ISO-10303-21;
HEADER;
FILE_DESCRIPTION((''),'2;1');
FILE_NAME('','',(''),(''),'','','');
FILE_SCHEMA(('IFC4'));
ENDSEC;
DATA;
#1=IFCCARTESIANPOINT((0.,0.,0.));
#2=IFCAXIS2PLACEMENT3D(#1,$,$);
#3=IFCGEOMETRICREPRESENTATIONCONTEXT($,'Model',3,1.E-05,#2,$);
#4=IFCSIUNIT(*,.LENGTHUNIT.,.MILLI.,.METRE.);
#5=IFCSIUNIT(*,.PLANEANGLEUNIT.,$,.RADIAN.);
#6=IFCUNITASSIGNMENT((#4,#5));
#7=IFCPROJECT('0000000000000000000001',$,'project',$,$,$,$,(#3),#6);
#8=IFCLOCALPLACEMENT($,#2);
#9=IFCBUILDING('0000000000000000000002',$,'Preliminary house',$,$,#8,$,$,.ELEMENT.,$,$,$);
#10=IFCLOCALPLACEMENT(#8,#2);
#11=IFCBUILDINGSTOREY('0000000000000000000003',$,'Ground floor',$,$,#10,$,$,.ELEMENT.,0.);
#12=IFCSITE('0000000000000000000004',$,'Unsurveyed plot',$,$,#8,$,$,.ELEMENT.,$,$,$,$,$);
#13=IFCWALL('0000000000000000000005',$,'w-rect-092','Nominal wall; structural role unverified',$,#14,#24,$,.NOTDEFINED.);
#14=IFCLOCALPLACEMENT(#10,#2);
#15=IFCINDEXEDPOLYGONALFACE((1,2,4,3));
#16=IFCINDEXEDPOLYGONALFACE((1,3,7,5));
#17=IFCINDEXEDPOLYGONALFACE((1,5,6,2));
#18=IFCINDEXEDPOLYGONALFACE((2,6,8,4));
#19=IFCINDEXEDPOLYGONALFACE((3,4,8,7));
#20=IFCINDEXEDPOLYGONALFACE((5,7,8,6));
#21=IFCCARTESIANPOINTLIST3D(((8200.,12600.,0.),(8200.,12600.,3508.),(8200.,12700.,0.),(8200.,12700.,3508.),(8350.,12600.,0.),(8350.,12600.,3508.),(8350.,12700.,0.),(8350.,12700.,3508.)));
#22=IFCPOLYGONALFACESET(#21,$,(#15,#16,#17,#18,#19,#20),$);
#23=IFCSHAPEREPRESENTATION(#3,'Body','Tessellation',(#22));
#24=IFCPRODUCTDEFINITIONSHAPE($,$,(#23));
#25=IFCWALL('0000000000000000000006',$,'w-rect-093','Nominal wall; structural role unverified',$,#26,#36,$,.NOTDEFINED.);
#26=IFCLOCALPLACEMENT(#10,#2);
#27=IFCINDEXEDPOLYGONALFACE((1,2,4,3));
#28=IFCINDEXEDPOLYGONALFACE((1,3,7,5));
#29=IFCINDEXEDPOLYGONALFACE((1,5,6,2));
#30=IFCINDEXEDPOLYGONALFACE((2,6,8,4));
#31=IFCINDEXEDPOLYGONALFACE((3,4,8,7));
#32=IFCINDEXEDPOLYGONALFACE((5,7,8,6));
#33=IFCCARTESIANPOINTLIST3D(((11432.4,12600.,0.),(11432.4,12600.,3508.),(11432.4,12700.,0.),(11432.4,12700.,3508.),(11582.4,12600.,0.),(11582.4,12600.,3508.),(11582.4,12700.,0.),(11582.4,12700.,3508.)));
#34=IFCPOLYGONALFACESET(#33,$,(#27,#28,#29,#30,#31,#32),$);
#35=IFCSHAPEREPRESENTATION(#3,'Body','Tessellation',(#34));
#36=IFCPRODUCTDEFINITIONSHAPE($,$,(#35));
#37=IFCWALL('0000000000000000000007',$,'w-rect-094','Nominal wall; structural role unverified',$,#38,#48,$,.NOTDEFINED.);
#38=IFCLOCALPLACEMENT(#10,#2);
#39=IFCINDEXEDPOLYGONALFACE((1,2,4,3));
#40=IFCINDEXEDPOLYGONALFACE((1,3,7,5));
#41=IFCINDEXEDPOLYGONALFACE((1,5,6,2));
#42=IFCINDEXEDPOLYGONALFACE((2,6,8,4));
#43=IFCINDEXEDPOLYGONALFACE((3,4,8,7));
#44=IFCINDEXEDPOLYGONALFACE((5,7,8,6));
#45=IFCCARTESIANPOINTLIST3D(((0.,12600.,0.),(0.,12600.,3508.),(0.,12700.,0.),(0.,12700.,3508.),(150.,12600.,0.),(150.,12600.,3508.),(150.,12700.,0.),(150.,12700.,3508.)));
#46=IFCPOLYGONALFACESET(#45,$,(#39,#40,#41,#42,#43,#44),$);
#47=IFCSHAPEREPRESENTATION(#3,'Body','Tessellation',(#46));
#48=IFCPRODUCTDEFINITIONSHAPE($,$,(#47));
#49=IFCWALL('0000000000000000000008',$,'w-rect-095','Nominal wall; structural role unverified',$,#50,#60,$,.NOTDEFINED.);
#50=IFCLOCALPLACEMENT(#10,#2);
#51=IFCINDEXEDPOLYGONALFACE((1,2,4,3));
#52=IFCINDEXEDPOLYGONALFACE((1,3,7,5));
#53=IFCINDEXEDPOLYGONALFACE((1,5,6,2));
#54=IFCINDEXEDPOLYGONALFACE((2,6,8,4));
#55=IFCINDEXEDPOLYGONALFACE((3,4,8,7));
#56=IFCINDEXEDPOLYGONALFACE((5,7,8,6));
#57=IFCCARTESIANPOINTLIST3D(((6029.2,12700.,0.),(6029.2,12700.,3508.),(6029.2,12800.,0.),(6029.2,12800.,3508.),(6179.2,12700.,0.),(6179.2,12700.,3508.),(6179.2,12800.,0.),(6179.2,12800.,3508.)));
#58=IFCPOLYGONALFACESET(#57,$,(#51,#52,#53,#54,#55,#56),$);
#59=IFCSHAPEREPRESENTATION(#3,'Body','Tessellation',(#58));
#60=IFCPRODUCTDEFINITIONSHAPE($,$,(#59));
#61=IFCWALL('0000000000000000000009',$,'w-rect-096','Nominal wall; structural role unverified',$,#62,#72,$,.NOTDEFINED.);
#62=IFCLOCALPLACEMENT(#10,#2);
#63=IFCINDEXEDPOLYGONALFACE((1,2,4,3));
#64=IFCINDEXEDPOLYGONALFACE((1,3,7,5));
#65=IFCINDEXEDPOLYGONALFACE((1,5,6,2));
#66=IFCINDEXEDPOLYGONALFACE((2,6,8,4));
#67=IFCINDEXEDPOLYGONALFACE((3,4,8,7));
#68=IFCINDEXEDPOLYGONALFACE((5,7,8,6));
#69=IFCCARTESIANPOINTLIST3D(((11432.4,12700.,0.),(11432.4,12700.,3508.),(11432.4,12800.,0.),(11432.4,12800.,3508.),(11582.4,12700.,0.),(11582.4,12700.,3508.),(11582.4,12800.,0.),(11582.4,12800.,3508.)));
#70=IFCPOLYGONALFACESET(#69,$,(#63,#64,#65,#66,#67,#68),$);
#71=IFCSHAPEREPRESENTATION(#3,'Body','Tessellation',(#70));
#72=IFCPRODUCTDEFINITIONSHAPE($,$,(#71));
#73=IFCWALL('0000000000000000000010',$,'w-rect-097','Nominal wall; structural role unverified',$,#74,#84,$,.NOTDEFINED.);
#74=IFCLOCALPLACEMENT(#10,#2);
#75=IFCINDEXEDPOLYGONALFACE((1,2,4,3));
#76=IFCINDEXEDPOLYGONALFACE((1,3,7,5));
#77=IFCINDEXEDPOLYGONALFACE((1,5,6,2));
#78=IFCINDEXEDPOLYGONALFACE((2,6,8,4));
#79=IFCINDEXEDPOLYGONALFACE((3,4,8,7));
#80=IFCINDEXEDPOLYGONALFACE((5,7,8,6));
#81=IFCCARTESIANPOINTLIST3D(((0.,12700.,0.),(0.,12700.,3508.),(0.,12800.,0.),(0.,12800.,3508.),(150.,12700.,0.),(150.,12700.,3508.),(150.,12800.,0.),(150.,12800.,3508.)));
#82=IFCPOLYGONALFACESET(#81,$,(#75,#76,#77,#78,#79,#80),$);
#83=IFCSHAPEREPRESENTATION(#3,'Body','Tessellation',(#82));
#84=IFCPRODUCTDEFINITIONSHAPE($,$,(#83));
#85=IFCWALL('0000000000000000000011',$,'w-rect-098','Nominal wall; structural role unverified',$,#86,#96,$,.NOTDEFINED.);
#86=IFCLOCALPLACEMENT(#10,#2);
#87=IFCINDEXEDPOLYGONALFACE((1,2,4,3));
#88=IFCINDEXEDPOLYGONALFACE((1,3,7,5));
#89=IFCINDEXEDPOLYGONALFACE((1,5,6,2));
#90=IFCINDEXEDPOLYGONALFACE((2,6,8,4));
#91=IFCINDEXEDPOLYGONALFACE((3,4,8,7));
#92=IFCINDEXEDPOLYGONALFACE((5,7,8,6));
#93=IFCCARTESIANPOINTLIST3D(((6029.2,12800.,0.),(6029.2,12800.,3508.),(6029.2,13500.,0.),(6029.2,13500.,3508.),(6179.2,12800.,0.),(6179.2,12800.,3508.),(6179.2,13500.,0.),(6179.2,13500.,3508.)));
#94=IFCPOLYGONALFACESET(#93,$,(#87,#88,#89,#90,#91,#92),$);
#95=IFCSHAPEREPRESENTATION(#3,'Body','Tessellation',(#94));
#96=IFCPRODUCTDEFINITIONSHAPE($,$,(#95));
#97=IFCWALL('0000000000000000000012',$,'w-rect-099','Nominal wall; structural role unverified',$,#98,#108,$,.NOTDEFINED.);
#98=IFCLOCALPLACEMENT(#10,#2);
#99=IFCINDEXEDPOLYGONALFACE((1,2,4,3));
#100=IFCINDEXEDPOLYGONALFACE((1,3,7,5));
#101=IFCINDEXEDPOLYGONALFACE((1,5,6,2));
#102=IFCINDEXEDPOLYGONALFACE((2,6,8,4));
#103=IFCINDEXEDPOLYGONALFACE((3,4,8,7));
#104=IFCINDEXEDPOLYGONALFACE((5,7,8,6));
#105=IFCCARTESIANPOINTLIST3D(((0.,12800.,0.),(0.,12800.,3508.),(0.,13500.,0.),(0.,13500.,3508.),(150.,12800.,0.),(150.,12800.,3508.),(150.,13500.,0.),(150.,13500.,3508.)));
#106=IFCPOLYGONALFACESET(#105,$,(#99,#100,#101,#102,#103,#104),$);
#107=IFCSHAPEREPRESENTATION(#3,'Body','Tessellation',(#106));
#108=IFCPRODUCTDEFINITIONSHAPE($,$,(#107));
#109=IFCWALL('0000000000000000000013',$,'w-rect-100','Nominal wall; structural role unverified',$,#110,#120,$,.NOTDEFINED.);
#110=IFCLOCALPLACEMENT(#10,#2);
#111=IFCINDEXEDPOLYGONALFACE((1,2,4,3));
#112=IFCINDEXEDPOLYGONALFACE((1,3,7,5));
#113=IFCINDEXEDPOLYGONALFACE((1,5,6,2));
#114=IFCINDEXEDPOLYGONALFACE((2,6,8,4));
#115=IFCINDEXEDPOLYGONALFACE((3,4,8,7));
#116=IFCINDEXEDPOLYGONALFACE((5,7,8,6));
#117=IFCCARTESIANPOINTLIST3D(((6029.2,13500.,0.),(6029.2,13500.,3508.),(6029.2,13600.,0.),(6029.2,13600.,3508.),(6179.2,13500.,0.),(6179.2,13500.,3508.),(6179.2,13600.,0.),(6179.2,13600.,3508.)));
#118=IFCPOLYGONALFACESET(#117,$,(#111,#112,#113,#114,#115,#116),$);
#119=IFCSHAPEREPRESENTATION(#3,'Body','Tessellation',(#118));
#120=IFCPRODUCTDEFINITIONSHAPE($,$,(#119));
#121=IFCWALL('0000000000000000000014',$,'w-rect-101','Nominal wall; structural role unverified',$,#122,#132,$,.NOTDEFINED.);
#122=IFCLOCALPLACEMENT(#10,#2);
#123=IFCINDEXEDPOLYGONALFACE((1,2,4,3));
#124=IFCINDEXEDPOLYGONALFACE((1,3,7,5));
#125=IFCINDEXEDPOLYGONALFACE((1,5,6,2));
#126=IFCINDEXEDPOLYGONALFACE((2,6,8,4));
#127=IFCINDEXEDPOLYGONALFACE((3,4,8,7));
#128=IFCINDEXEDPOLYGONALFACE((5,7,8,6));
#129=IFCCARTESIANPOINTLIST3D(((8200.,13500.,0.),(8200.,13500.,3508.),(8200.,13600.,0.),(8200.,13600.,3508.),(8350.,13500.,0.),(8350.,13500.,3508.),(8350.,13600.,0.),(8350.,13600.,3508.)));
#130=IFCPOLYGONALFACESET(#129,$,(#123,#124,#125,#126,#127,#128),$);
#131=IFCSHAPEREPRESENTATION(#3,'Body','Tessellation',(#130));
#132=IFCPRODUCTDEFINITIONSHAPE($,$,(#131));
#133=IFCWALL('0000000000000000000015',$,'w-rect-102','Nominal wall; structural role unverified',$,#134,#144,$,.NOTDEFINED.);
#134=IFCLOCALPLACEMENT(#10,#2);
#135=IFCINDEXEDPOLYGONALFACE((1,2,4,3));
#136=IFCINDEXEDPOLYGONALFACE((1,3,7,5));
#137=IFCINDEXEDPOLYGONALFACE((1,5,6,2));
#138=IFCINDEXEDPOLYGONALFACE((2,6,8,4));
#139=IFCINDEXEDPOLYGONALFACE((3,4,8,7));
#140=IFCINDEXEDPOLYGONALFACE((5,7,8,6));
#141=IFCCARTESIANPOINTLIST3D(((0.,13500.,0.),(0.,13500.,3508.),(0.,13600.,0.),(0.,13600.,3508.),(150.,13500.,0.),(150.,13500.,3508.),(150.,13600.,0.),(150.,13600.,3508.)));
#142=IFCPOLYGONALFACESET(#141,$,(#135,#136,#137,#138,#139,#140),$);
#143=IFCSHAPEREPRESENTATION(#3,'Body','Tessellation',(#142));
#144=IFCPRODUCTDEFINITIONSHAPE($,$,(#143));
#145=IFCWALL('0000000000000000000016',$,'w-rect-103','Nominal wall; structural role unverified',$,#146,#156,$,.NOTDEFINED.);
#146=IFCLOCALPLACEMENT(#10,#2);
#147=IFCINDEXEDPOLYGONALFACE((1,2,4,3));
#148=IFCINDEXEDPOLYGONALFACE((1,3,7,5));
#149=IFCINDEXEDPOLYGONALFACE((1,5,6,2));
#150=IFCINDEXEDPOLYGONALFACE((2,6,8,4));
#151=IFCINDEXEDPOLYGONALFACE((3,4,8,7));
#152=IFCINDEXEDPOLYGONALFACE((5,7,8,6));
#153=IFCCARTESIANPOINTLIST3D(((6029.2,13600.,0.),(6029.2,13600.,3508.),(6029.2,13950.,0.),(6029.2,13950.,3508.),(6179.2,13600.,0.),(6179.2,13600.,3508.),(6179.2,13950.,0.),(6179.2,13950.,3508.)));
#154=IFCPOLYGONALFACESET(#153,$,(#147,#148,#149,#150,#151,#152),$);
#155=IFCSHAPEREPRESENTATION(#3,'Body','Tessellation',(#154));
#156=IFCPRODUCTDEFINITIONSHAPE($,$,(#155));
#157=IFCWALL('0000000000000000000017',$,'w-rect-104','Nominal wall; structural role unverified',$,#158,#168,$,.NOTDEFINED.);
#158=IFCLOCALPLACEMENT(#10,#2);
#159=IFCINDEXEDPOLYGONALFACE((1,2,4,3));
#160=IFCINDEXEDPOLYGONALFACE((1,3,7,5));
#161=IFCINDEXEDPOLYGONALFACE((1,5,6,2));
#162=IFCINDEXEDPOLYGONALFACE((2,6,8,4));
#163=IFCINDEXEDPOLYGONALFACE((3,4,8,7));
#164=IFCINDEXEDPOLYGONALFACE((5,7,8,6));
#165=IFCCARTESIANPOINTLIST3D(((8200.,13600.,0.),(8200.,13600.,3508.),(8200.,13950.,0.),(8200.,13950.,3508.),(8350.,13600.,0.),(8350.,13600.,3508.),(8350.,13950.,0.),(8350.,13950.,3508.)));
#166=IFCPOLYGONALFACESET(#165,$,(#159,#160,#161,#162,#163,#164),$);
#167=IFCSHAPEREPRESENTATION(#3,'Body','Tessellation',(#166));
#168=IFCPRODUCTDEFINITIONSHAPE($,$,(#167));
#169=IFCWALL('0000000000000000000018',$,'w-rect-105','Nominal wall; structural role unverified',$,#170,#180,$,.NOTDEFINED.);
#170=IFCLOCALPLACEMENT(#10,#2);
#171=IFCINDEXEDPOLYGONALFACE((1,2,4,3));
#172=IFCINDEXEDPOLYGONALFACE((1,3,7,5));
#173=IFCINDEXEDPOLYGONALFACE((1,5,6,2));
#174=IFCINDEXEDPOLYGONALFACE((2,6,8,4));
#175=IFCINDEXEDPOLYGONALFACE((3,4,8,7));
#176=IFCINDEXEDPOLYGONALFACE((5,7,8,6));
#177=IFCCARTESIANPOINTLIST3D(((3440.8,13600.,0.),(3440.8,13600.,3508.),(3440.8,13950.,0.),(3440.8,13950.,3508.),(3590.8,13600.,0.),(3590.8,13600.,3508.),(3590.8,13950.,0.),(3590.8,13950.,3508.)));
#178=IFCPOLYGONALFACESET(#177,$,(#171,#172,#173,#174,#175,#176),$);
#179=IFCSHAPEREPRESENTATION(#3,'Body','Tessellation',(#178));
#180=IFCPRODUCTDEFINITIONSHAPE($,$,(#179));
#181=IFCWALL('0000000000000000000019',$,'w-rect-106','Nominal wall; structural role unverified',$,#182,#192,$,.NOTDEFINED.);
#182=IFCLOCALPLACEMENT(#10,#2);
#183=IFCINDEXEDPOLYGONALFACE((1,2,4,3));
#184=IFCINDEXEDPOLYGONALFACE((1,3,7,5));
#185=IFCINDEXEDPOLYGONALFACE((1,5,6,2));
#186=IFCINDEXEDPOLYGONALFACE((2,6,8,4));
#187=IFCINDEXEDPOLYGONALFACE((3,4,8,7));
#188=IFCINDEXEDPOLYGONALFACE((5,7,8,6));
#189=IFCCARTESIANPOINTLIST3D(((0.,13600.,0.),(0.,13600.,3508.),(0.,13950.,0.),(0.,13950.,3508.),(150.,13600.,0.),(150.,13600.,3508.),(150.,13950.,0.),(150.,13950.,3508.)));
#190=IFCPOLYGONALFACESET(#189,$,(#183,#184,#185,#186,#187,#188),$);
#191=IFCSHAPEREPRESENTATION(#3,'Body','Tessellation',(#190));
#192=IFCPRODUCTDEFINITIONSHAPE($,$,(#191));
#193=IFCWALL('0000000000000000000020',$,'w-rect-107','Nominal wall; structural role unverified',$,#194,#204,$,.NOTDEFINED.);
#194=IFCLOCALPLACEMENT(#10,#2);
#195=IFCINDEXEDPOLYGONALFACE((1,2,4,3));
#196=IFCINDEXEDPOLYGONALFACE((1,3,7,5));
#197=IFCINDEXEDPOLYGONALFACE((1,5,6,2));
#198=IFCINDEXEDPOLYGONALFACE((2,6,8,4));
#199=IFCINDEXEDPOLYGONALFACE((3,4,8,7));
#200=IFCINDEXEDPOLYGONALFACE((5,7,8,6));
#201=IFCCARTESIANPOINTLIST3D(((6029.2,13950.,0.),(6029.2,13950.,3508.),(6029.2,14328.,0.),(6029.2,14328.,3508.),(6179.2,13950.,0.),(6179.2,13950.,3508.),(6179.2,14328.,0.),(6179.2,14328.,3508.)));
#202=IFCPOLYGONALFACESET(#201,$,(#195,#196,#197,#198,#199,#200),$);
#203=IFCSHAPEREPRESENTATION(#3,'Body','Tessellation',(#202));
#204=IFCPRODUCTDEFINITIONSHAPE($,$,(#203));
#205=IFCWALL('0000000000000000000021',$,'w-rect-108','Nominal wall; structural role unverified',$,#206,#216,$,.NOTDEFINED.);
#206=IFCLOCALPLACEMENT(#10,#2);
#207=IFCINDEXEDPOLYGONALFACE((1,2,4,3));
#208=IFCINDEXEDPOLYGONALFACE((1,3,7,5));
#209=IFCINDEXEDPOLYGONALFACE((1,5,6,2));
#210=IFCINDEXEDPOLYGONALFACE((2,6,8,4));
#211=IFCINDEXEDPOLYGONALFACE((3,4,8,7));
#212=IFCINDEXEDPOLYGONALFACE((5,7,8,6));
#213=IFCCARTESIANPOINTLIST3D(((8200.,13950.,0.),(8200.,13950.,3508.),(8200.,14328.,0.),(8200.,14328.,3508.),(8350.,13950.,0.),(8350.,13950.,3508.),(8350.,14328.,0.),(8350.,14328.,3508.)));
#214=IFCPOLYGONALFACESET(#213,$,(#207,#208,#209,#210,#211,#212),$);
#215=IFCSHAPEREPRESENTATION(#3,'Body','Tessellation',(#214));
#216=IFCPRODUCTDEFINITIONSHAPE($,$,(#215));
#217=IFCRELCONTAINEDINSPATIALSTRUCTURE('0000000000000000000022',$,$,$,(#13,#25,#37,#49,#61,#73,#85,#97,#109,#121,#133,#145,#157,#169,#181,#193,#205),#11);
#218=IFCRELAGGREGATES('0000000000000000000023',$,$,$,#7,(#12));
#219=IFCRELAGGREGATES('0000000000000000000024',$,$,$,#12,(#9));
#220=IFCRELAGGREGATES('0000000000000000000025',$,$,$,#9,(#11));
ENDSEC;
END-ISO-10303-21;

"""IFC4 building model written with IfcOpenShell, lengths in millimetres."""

from ifc_helpers import new_model, si_unit, origin, place, context, project, spatial, polyline, outline, extrude, element, save


model = new_model("IFC4")

# Units and contexts
model_context = context("Model", 3, precision=1e-05, world=origin())
ifc_project = project(units=[si_unit("LENGTHUNIT", "METRE", prefix="MILLI"), si_unit("PLANEANGLEUNIT", "RADIAN")], contexts=[model_context])

# Site, building, storey
placement_1 = place(None, origin())
site = spatial("IfcSite", under=ifc_project, at=placement_1, Name="Unsurveyed plot", CompositionType="ELEMENT")
building = spatial("IfcBuilding", under=site, at=placement_1, Name="Preliminary house", CompositionType="ELEMENT")
placement_2 = place(placement_1, origin())
storey = spatial("IfcBuildingStorey", under=building, at=placement_2, Name="Ground floor", CompositionType="ELEMENT", Elevation=0.0)

# Walls
element("IfcWall", 1, at=placement_2, inside=storey, Name="w-rect-092", Description="Nominal wall; structural role unverified", PredefinedType="NOTDEFINED", context=model_context, shape_type="SweptSolid", body=[
    extrude(outline(polyline([(8200.0, 12600.0), (8350.0, 12600.0), (8350.0, 12700.0), (8200.0, 12700.0), (8200.0, 12600.0)])), origin(), (0.0, 0.0, 1.0), 3508.0),
])
element("IfcWall", 2, at=placement_2, inside=storey, Name="w-rect-093", Description="Nominal wall; structural role unverified", PredefinedType="NOTDEFINED", context=model_context, shape_type="SweptSolid", body=[
    extrude(outline(polyline([(11432.4, 12600.0), (11582.4, 12600.0), (11582.4, 12700.0), (11432.4, 12700.0), (11432.4, 12600.0)])), origin(), (0.0, 0.0, 1.0), 3508.0),
])
element("IfcWall", 3, at=placement_2, inside=storey, Name="w-rect-094", Description="Nominal wall; structural role unverified", PredefinedType="NOTDEFINED", context=model_context, shape_type="SweptSolid", body=[
    extrude(outline(polyline([(0.0, 12600.0), (150.0, 12600.0), (150.0, 12700.0), (0.0, 12700.0), (0.0, 12600.0)])), origin(), (0.0, 0.0, 1.0), 3508.0),
])
element("IfcWall", 4, at=placement_2, inside=storey, Name="w-rect-095", Description="Nominal wall; structural role unverified", PredefinedType="NOTDEFINED", context=model_context, shape_type="SweptSolid", body=[
    extrude(outline(polyline([(6029.2, 12700.0), (6179.2, 12700.0), (6179.2, 12800.0), (6029.2, 12800.0), (6029.2, 12700.0)])), origin(), (0.0, 0.0, 1.0), 3508.0),
])
element("IfcWall", 5, at=placement_2, inside=storey, Name="w-rect-096", Description="Nominal wall; structural role unverified", PredefinedType="NOTDEFINED", context=model_context, shape_type="SweptSolid", body=[
    extrude(outline(polyline([(11432.4, 12700.0), (11582.4, 12700.0), (11582.4, 12800.0), (11432.4, 12800.0), (11432.4, 12700.0)])), origin(), (0.0, 0.0, 1.0), 3508.0),
])
element("IfcWall", 6, at=placement_2, inside=storey, Name="w-rect-097", Description="Nominal wall; structural role unverified", PredefinedType="NOTDEFINED", context=model_context, shape_type="SweptSolid", body=[
    extrude(outline(polyline([(0.0, 12700.0), (150.0, 12700.0), (150.0, 12800.0), (0.0, 12800.0), (0.0, 12700.0)])), origin(), (0.0, 0.0, 1.0), 3508.0),
])
element("IfcWall", 7, at=placement_2, inside=storey, Name="w-rect-098", Description="Nominal wall; structural role unverified", PredefinedType="NOTDEFINED", context=model_context, shape_type="SweptSolid", body=[
    extrude(outline(polyline([(6029.2, 12800.0), (6179.2, 12800.0), (6179.2, 13500.0), (6029.2, 13500.0), (6029.2, 12800.0)])), origin(), (0.0, 0.0, 1.0), 3508.0),
])
element("IfcWall", 8, at=placement_2, inside=storey, Name="w-rect-099", Description="Nominal wall; structural role unverified", PredefinedType="NOTDEFINED", context=model_context, shape_type="SweptSolid", body=[
    extrude(outline(polyline([(0.0, 12800.0), (150.0, 12800.0), (150.0, 13500.0), (0.0, 13500.0), (0.0, 12800.0)])), origin(), (0.0, 0.0, 1.0), 3508.0),
])
element("IfcWall", 9, at=placement_2, inside=storey, Name="w-rect-100", Description="Nominal wall; structural role unverified", PredefinedType="NOTDEFINED", context=model_context, shape_type="SweptSolid", body=[
    extrude(outline(polyline([(6029.2, 13500.0), (6179.2, 13500.0), (6179.2, 13600.0), (6029.2, 13600.0), (6029.2, 13500.0)])), origin(), (0.0, 0.0, 1.0), 3508.0),
])
element("IfcWall", 10, at=placement_2, inside=storey, Name="w-rect-101", Description="Nominal wall; structural role unverified", PredefinedType="NOTDEFINED", context=model_context, shape_type="SweptSolid", body=[
    extrude(outline(polyline([(8200.0, 13500.0), (8350.0, 13500.0), (8350.0, 13600.0), (8200.0, 13600.0), (8200.0, 13500.0)])), origin(), (0.0, 0.0, 1.0), 3508.0),
])
element("IfcWall", 11, at=placement_2, inside=storey, Name="w-rect-102", Description="Nominal wall; structural role unverified", PredefinedType="NOTDEFINED", context=model_context, shape_type="SweptSolid", body=[
    extrude(outline(polyline([(0.0, 13500.0), (150.0, 13500.0), (150.0, 13600.0), (0.0, 13600.0), (0.0, 13500.0)])), origin(), (0.0, 0.0, 1.0), 3508.0),
])
element("IfcWall", 12, at=placement_2, inside=storey, Name="w-rect-103", Description="Nominal wall; structural role unverified", PredefinedType="NOTDEFINED", context=model_context, shape_type="SweptSolid", body=[
    extrude(outline(polyline([(6029.2, 13600.0), (6179.2, 13600.0), (6179.2, 13950.0), (6029.2, 13950.0), (6029.2, 13600.0)])), origin(), (0.0, 0.0, 1.0), 3508.0),
])
element("IfcWall", 13, at=placement_2, inside=storey, Name="w-rect-104", Description="Nominal wall; structural role unverified", PredefinedType="NOTDEFINED", context=model_context, shape_type="SweptSolid", body=[
    extrude(outline(polyline([(8200.0, 13600.0), (8350.0, 13600.0), (8350.0, 13950.0), (8200.0, 13950.0), (8200.0, 13600.0)])), origin(), (0.0, 0.0, 1.0), 3508.0),
])
element("IfcWall", 14, at=placement_2, inside=storey, Name="w-rect-105", Description="Nominal wall; structural role unverified", PredefinedType="NOTDEFINED", context=model_context, shape_type="SweptSolid", body=[
    extrude(outline(polyline([(3440.8, 13600.0), (3590.8, 13600.0), (3590.8, 13950.0), (3440.8, 13950.0), (3440.8, 13600.0)])), origin(), (0.0, 0.0, 1.0), 3508.0),
])
element("IfcWall", 15, at=placement_2, inside=storey, Name="w-rect-106", Description="Nominal wall; structural role unverified", PredefinedType="NOTDEFINED", context=model_context, shape_type="SweptSolid", body=[
    extrude(outline(polyline([(0.0, 13600.0), (150.0, 13600.0), (150.0, 13950.0), (0.0, 13950.0), (0.0, 13600.0)])), origin(), (0.0, 0.0, 1.0), 3508.0),
])
element("IfcWall", 16, at=placement_2, inside=storey, Name="w-rect-107", Description="Nominal wall; structural role unverified", PredefinedType="NOTDEFINED", context=model_context, shape_type="SweptSolid", body=[
    extrude(outline(polyline([(6029.2, 13950.0), (6179.2, 13950.0), (6179.2, 14328.0), (6029.2, 14328.0), (6029.2, 13950.0)])), origin(), (0.0, 0.0, 1.0), 3508.0),
])
element("IfcWall", 17, at=placement_2, inside=storey, Name="w-rect-108", Description="Nominal wall; structural role unverified", PredefinedType="NOTDEFINED", context=model_context, shape_type="SweptSolid", body=[
    extrude(outline(polyline([(8200.0, 13950.0), (8350.0, 13950.0), (8350.0, 14328.0), (8200.0, 14328.0), (8200.0, 13950.0)])), origin(), (0.0, 0.0, 1.0), 3508.0),
])

save(model, "model.ifc")
